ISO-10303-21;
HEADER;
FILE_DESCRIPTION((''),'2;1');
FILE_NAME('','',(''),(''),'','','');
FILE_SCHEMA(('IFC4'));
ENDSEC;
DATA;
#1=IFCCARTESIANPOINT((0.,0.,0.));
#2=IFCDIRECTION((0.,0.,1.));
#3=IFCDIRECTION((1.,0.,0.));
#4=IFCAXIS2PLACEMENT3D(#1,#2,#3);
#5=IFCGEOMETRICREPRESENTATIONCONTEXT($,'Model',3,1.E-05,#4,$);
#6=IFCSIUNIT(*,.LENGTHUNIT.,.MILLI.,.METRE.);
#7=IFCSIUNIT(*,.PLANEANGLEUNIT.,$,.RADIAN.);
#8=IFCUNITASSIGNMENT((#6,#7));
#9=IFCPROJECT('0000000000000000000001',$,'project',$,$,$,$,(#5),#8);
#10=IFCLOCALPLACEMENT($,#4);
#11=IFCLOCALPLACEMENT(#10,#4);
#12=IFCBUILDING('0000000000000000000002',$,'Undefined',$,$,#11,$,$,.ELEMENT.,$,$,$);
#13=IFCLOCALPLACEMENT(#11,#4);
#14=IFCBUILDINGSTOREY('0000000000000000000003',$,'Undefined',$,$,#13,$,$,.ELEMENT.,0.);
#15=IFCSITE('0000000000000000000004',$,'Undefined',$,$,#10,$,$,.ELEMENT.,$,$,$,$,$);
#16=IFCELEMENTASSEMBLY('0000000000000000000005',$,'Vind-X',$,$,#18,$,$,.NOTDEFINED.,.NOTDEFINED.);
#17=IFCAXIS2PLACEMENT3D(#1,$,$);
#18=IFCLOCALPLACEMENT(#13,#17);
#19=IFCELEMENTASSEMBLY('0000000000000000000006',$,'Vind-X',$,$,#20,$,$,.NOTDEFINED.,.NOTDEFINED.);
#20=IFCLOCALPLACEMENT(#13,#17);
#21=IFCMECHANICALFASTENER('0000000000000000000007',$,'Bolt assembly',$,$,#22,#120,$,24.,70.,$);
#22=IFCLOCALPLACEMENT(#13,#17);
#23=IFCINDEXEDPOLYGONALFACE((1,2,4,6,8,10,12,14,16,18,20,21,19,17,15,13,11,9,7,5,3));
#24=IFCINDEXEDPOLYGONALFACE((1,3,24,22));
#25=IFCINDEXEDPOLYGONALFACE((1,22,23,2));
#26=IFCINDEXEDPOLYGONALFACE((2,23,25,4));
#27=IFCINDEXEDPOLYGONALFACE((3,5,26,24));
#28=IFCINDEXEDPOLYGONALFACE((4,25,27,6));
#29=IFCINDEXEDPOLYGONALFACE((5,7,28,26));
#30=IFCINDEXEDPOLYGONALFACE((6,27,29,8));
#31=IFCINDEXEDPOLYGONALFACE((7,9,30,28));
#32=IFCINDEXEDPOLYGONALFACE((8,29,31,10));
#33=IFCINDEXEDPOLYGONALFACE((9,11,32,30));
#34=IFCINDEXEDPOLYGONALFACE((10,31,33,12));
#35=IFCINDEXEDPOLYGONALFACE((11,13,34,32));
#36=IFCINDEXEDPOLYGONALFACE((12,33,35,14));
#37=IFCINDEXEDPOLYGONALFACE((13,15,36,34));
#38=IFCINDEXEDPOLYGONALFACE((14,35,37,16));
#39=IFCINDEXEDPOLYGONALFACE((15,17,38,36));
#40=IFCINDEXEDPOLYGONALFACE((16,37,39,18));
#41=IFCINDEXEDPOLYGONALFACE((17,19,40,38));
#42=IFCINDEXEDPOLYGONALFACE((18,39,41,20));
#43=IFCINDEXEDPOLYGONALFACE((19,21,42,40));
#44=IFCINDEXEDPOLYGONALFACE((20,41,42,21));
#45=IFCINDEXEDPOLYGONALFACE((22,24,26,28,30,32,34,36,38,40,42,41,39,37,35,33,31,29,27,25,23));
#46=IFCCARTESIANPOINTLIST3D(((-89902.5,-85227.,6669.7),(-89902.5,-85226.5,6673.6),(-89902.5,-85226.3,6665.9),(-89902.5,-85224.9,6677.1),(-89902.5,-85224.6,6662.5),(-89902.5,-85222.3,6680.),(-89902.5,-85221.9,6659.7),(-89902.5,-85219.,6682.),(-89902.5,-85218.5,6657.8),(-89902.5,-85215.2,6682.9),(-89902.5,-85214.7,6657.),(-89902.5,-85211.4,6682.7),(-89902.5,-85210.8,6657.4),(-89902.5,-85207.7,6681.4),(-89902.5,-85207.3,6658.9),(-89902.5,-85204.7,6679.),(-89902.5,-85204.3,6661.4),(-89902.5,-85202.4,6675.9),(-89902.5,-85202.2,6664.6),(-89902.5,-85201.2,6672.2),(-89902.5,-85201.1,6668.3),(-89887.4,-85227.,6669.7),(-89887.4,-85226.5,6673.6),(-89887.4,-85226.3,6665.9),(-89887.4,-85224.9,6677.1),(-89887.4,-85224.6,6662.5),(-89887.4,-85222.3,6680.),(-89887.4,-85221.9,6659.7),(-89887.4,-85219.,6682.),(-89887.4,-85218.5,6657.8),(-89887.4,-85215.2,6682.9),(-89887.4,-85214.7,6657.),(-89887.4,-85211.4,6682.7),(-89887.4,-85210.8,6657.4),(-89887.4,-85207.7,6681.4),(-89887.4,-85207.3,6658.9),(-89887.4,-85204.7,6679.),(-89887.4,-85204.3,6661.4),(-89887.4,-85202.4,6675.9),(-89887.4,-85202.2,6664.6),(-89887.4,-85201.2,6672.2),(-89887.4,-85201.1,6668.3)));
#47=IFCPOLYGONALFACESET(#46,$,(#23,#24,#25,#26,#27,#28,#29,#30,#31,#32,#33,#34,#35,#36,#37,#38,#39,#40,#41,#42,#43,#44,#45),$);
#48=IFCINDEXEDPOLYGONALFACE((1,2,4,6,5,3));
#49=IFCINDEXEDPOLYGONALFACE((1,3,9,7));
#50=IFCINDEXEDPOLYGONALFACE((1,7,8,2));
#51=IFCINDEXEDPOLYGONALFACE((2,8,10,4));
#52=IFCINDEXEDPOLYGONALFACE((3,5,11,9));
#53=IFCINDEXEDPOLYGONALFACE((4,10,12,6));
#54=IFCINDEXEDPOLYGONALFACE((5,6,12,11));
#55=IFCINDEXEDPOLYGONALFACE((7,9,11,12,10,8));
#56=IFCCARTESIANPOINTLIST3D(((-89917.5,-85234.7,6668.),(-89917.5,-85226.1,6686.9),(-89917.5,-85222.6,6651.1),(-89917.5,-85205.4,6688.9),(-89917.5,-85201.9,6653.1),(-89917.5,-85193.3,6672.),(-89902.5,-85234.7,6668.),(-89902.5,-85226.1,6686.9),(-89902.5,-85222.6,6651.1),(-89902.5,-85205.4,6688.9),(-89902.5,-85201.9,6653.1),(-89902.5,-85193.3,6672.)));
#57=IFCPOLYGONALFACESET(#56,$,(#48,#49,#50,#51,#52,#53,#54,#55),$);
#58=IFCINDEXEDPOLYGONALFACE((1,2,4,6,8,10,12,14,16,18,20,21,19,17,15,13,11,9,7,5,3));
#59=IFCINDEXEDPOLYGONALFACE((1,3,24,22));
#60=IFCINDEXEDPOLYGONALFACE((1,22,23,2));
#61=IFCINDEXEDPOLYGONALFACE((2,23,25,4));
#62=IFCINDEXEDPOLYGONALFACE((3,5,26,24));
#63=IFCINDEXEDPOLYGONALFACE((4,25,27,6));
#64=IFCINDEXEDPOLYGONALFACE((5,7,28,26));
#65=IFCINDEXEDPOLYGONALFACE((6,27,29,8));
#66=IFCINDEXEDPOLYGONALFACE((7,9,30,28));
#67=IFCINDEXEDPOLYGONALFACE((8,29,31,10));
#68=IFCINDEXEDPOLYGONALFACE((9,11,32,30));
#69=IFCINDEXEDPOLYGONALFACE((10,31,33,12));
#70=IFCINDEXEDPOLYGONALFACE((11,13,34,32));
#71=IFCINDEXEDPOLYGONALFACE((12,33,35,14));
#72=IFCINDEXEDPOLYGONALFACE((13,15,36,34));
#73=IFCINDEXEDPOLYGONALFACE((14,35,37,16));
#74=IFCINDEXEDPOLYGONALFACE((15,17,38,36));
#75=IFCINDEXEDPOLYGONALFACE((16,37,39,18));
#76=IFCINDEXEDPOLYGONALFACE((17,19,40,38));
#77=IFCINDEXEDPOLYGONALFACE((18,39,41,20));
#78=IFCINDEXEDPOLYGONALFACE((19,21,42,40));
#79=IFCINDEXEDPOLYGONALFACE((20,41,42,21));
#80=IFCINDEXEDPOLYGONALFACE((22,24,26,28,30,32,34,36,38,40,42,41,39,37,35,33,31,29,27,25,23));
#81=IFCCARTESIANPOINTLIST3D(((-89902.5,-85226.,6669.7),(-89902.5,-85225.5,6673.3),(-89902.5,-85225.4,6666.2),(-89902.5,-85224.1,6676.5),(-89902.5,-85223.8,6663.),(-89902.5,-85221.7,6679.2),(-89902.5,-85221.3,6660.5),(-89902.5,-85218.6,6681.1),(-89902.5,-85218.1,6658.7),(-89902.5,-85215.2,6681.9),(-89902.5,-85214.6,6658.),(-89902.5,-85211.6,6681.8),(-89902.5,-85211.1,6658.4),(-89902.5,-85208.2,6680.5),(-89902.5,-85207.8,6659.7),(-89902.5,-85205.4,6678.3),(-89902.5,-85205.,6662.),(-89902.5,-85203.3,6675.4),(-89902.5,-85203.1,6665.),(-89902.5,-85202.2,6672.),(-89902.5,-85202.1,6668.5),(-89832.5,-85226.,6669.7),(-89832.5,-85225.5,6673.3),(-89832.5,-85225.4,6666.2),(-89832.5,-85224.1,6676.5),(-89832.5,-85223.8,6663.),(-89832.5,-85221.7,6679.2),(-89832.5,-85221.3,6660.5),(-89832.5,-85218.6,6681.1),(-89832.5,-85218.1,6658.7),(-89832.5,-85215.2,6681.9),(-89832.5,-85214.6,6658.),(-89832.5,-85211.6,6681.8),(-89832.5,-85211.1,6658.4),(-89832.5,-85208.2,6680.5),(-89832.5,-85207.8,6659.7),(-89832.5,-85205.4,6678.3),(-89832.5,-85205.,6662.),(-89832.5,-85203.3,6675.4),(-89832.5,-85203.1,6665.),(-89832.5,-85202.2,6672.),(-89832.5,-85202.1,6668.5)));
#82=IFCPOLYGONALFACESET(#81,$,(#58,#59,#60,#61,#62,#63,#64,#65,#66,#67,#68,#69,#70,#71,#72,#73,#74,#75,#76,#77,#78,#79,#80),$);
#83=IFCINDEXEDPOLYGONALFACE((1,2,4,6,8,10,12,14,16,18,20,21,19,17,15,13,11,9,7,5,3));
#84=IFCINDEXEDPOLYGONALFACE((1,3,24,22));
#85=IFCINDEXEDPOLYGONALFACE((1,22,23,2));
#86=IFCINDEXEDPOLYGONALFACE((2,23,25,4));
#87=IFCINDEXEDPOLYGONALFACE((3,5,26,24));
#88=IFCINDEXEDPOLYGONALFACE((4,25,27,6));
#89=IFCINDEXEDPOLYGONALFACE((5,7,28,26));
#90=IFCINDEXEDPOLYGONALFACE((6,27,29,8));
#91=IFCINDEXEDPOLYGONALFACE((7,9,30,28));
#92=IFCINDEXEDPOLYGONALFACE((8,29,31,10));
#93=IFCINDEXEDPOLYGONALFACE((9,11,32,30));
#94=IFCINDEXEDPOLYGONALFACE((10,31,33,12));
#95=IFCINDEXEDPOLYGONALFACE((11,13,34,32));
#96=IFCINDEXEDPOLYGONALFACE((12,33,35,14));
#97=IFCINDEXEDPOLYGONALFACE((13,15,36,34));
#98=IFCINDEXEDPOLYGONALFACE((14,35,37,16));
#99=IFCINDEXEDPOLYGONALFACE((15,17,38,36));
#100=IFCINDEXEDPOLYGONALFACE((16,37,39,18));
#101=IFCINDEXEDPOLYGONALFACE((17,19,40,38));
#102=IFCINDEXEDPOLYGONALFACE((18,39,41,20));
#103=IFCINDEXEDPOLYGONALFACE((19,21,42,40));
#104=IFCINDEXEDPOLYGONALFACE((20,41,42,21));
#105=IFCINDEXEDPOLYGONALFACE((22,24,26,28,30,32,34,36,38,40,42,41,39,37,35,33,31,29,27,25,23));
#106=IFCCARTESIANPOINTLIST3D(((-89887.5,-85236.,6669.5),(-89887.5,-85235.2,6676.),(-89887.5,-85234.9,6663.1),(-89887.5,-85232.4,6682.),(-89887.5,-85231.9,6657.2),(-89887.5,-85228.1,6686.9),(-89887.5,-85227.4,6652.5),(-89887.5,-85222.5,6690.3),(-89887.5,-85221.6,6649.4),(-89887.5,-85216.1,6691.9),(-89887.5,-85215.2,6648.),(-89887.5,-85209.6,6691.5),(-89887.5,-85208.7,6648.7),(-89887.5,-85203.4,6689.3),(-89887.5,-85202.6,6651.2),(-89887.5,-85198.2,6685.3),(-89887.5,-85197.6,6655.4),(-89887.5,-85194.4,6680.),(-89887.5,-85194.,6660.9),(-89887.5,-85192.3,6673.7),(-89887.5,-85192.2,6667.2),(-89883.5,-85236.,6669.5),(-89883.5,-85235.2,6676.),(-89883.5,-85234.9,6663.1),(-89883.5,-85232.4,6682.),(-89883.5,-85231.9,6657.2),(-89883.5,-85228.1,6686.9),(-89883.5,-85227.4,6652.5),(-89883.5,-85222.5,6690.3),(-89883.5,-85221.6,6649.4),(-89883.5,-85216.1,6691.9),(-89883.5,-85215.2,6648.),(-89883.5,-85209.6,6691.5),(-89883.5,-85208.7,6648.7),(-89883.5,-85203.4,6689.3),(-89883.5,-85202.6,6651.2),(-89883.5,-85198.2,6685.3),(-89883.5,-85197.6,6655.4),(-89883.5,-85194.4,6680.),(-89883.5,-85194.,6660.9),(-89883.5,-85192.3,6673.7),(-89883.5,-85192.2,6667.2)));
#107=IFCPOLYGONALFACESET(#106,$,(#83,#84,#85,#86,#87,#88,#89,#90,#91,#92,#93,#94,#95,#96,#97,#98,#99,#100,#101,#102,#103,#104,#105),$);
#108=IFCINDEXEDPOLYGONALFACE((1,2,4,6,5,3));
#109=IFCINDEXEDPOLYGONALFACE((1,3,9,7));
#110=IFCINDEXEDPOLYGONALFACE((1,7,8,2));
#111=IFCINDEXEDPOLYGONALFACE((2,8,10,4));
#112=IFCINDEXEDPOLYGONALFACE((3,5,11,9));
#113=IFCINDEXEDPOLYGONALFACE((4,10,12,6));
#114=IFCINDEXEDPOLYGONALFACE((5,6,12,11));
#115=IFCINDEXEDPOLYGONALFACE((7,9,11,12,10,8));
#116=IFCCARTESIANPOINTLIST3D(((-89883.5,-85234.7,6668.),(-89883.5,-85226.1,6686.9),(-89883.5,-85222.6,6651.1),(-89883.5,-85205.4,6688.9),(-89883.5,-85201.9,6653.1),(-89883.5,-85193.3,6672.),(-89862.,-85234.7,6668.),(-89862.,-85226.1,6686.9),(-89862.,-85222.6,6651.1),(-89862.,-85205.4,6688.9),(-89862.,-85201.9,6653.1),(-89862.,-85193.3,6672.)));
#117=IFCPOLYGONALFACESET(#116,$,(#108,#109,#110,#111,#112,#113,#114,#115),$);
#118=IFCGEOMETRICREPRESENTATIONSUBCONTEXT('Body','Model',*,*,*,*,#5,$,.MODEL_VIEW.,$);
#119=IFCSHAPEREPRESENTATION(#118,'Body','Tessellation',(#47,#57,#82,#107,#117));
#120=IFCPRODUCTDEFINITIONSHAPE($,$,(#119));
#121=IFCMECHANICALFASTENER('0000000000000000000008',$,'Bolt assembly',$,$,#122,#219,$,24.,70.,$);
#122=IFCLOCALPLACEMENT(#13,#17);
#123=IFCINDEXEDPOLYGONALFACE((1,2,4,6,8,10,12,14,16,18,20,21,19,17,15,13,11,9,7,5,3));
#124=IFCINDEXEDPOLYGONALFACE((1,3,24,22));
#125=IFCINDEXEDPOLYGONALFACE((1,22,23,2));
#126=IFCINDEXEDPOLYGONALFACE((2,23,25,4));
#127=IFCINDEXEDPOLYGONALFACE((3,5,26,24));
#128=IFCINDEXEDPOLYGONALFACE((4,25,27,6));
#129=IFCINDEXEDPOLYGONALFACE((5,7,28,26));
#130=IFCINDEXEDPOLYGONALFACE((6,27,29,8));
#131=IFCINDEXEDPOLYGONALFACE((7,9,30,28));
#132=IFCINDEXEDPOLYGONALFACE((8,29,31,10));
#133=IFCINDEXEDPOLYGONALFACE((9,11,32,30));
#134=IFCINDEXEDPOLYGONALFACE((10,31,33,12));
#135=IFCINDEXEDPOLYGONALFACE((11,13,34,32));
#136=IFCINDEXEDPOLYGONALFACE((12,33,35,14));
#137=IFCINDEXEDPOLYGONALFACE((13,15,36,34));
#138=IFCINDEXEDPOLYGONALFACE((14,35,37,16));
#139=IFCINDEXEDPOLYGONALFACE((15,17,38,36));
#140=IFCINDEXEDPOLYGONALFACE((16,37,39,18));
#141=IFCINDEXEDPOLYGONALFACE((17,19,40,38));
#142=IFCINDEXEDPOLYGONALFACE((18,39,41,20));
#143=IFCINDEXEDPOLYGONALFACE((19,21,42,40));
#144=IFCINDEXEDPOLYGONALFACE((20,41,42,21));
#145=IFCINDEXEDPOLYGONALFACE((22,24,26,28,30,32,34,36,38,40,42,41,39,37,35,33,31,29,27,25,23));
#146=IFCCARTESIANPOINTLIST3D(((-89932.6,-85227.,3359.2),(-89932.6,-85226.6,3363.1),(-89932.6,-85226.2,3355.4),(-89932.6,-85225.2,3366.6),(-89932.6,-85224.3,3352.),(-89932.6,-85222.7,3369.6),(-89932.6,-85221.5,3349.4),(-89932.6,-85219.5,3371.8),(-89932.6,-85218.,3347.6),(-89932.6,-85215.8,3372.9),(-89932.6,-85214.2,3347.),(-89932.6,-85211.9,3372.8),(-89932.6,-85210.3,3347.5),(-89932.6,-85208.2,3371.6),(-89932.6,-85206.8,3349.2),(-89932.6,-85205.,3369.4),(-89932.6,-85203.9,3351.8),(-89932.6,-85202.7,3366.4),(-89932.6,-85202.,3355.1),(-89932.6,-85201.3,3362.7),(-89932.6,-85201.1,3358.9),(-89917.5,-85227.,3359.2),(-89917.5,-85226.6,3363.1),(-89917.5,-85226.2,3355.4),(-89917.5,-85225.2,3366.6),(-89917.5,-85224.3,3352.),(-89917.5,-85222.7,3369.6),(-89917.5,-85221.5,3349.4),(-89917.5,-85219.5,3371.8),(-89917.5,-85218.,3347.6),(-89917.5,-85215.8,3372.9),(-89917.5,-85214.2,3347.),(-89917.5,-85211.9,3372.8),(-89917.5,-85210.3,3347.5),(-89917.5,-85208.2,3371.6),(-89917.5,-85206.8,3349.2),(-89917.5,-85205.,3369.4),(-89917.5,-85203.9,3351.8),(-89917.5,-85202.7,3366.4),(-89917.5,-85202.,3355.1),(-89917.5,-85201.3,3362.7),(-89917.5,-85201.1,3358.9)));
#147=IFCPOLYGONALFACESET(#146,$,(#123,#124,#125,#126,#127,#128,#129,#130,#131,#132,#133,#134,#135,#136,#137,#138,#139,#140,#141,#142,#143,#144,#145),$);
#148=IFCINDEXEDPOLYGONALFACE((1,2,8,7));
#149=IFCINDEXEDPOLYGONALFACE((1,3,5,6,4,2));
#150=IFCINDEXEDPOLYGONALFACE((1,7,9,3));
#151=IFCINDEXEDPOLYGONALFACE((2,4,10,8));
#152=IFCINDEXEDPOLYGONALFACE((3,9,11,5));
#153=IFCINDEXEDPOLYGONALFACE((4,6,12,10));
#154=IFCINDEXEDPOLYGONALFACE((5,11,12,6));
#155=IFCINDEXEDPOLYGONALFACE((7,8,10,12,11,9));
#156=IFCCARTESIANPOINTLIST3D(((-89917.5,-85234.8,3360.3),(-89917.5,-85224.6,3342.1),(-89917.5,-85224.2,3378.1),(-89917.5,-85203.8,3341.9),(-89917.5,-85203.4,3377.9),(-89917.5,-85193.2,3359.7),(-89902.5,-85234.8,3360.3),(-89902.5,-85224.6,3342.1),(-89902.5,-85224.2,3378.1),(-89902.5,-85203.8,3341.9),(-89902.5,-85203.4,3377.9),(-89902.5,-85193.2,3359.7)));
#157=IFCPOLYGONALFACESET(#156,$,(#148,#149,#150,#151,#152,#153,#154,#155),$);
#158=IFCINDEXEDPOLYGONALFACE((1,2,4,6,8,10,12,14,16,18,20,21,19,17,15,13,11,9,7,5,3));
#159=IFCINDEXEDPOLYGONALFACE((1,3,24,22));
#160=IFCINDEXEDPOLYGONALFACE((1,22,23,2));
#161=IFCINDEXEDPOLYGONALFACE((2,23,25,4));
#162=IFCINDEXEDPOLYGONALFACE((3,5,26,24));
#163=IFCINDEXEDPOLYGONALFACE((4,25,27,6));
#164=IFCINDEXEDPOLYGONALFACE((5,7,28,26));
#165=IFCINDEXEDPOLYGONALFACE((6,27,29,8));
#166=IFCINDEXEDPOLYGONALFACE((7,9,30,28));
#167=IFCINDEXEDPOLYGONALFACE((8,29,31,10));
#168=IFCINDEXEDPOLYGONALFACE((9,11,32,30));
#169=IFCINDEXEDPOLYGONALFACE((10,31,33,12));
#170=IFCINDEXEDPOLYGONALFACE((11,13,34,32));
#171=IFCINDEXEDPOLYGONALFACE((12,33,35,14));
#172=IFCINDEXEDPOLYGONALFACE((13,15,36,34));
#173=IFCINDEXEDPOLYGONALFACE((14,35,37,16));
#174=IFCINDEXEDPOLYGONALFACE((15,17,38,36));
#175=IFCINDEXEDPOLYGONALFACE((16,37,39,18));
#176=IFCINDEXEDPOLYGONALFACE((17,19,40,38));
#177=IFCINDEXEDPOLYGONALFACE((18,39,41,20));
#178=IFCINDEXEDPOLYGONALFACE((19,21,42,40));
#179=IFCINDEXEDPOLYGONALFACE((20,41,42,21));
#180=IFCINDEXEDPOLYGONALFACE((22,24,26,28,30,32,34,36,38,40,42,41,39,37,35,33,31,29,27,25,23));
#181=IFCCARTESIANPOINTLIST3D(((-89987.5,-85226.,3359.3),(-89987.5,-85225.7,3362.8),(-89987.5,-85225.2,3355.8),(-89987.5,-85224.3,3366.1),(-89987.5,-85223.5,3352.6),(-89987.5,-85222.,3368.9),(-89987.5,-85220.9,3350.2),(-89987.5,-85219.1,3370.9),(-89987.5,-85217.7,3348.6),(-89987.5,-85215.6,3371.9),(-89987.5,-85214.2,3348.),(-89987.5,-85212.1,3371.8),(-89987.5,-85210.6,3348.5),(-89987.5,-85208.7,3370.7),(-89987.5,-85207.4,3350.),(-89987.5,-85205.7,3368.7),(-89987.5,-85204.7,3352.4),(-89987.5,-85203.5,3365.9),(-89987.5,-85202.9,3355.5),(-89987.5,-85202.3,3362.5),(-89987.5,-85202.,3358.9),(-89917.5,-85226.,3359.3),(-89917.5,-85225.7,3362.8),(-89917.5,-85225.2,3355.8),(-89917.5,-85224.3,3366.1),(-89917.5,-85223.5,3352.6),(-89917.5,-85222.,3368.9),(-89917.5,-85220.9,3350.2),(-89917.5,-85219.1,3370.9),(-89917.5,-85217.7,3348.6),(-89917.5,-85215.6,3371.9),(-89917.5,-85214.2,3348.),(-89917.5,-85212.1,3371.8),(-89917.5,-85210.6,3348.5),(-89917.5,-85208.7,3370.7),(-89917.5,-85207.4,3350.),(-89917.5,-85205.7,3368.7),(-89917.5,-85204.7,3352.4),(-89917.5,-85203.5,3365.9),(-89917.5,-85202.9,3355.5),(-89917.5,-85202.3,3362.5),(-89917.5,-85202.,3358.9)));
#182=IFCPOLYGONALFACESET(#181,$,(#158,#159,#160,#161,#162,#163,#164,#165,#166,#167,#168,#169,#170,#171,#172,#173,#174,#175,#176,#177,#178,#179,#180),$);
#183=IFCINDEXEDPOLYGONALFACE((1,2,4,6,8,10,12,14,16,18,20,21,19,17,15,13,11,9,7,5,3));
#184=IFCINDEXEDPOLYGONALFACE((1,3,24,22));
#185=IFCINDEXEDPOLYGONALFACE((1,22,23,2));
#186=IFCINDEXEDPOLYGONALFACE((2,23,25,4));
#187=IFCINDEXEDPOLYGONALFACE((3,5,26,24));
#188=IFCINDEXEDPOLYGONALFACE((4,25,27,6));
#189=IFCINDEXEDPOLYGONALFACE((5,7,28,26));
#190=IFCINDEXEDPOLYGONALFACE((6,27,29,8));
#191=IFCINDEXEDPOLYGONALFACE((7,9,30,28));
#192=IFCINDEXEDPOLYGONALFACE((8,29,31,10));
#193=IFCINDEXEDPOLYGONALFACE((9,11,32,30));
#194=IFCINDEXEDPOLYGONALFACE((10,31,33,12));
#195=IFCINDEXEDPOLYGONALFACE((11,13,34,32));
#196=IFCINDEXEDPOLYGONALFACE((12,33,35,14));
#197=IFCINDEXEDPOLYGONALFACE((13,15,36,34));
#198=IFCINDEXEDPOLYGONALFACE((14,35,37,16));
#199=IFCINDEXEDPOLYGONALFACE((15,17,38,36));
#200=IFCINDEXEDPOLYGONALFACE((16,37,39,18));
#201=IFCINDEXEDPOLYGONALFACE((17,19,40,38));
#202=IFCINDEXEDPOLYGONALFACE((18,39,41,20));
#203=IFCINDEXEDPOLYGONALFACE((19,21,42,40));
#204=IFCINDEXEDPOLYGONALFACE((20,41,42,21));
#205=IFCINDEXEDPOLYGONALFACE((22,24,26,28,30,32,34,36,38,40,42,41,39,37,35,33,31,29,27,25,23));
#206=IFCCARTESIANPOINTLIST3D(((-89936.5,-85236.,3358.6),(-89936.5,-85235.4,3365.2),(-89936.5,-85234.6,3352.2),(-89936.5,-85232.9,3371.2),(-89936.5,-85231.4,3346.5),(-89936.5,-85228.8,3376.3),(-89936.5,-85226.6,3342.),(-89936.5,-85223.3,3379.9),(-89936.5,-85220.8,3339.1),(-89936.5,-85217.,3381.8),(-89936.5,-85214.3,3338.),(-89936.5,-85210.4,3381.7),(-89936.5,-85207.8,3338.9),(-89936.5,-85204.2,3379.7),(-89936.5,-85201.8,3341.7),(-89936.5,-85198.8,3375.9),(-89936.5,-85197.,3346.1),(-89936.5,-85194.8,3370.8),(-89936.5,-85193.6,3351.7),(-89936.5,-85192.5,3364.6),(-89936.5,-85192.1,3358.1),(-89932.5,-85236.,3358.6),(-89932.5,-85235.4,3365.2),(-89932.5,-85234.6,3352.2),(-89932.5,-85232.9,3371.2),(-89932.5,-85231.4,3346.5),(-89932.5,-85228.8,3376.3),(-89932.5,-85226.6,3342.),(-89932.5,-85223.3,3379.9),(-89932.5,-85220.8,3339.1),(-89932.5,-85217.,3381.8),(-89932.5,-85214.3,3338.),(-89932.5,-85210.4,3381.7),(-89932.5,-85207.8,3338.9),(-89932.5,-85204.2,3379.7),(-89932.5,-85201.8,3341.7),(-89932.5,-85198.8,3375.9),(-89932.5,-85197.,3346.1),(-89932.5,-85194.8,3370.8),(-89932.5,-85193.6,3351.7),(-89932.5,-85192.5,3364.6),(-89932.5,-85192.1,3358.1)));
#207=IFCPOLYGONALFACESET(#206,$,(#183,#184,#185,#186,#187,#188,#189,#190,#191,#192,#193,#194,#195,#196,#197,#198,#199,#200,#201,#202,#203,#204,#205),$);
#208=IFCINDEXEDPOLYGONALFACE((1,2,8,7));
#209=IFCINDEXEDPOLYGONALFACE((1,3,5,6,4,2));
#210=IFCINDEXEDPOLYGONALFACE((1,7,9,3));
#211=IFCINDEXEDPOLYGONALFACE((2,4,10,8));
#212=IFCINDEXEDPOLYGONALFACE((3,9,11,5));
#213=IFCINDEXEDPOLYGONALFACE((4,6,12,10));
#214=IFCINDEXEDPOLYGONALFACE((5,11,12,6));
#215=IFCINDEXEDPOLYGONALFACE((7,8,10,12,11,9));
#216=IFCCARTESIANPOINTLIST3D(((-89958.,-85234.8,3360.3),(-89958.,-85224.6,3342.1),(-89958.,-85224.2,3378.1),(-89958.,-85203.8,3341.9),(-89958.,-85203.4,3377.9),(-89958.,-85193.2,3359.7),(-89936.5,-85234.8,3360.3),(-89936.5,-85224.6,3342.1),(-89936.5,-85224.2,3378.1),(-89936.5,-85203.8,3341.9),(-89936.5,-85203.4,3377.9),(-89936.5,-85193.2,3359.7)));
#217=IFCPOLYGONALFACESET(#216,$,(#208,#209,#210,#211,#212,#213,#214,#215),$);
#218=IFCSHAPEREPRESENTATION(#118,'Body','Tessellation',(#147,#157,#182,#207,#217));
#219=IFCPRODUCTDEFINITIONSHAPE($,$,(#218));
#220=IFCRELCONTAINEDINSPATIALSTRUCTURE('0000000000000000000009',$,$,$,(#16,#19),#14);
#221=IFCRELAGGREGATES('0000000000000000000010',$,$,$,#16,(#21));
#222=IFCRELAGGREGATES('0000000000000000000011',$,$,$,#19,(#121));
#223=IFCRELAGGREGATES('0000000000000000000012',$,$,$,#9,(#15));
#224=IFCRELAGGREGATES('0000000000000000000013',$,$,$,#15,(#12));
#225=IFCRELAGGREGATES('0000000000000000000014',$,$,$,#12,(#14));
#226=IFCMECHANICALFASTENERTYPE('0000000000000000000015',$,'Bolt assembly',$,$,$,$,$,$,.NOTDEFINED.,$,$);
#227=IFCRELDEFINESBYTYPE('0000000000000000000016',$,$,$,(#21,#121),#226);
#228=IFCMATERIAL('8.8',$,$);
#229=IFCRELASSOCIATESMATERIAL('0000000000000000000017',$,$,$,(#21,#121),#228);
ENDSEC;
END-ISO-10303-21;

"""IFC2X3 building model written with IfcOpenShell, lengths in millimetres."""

from ifc_helpers import new_model, si_unit, frame, origin_with_axes, origin_2d_with_axis, place, context, subcontext, project, spatial, polyline, circle, outline, extrude, source, transform, mapped, material, type_object, element, aggregate, save


model = new_model("IFC2X3")

# Units and contexts
model_context = context("Model", 3, precision=1e-05, world=origin_with_axes())
body_context = subcontext(model_context, "Body", "Model", "MODEL_VIEW")
ifc_project = project(units=[si_unit("LENGTHUNIT", "METRE", prefix="MILLI"), si_unit("PLANEANGLEUNIT", "RADIAN")], contexts=[model_context])

# Site, building, storey
site_placement = place(None, origin_with_axes())
site = spatial("IfcSite", under=ifc_project, at=site_placement, Name="Undefined", CompositionType="ELEMENT")
building_placement = place(site_placement, origin_with_axes())
building = spatial("IfcBuilding", under=site, at=building_placement, Name="Undefined", CompositionType="ELEMENT")
storey_placement = place(building_placement, origin_with_axes())
storey = spatial("IfcBuildingStorey", under=building, at=storey_placement, Name="Undefined", CompositionType="ELEMENT", Elevation=0.0)

# Element assemblies
assembly_1_placement = place(storey_placement, origin_with_axes())
assembly_1 = element("IfcElementAssembly", 1, at=assembly_1_placement, inside=storey, Name="Vind-X", AssemblyPlace="NOTDEFINED", PredefinedType="NOTDEFINED")
assembly_2_placement = place(storey_placement, origin_with_axes())
assembly_2 = element("IfcElementAssembly", 2, at=assembly_2_placement, inside=storey, Name="Vind-X", AssemblyPlace="NOTDEFINED", PredefinedType="NOTDEFINED")

# Mechanical fasteners
ifc_material_1 = material(Name="8.8")
mechanical_fastener_type = type_object("IfcMechanicalFastenerType", Name="Bolt assembly")
shared_shape_1 = source(origin_with_axes(), body_context, "Body", "SweptSolid", [
    extrude(circle(Radius=13.0, at=origin_2d_with_axis()), frame((0.0, 0.0, 0.0), z_axis=(0.0, 1.0, 0.0), x_axis=(1.0, 0.0, 0.0)), (0.0, 0.0, 1.0), 15.1),
    extrude(outline(polyline([(18.0, -10.4), (18.0, 10.4), (0.0, 20.8), (-18.0, 10.4), (-18.0, -10.4), (0.0, -20.8), (18.0, -10.4)])), frame((0.0, -15.0, 0.0), z_axis=(0.0, 1.0, 0.0), x_axis=(1.0, 0.0, 0.0)), (0.0, 0.0, 1.0), 15.0),
    extrude(circle(Radius=12.0, at=origin_2d_with_axis()), frame((0.0, 0.0, 0.0), z_axis=(0.0, 1.0, 0.0), x_axis=(1.0, 0.0, 0.0)), (0.0, 0.0, 1.0), 70.0),
    extrude(circle(Radius=22.0, at=origin_2d_with_axis()), frame((0.0, 15.0, 0.0), z_axis=(0.0, 1.0, 0.0), x_axis=(1.0, 0.0, 0.0)), (0.0, 0.0, 1.0), 4.0),
    extrude(outline(polyline([(18.0, -10.4), (18.0, 10.4), (0.0, 20.8), (-18.0, 10.4), (-18.0, -10.4), (0.0, -20.8), (18.0, -10.4)])), frame((0.0, 19.0, 0.0), z_axis=(0.0, 1.0, 0.0), x_axis=(1.0, 0.0, 0.0)), (0.0, 0.0, 1.0), 21.5),
])
mechanical_fastener_1_placement = place(assembly_1_placement, frame((-89902.5, -85214.0, 6670.0), z_axis=(0.0, -0.58074, 0.814089), x_axis=(0.0, -0.814089, -0.58074)))
mechanical_fastener_1 = element("IfcMechanicalFastener", 3, at=mechanical_fastener_1_placement, type_object=mechanical_fastener_type, material=ifc_material_1, Name="Bolt assembly", NominalDiameter=24.0, NominalLength=70.0, context=body_context, shape_type="MappedRepresentation", body=[
    mapped(shared_shape_1, transform((0.0, 0.0, 0.0))),
])
aggregate(assembly_1, [mechanical_fastener_1])
mechanical_fastener_2_placement = place(assembly_2_placement, frame((-89917.5, -85214.0, 3360.0), z_axis=(0.0, -0.511223, -0.859448), x_axis=(0.0, -0.859448, 0.511223)))
mechanical_fastener_2 = element("IfcMechanicalFastener", 4, at=mechanical_fastener_2_placement, type_object=mechanical_fastener_type, material=ifc_material_1, Name="Bolt assembly", NominalDiameter=24.0, NominalLength=70.0, context=body_context, shape_type="MappedRepresentation", body=[
    mapped(shared_shape_1, transform((0.0, 0.0, 0.0))),
])
aggregate(assembly_2, [mechanical_fastener_2])

save(model, "model.ifc")
